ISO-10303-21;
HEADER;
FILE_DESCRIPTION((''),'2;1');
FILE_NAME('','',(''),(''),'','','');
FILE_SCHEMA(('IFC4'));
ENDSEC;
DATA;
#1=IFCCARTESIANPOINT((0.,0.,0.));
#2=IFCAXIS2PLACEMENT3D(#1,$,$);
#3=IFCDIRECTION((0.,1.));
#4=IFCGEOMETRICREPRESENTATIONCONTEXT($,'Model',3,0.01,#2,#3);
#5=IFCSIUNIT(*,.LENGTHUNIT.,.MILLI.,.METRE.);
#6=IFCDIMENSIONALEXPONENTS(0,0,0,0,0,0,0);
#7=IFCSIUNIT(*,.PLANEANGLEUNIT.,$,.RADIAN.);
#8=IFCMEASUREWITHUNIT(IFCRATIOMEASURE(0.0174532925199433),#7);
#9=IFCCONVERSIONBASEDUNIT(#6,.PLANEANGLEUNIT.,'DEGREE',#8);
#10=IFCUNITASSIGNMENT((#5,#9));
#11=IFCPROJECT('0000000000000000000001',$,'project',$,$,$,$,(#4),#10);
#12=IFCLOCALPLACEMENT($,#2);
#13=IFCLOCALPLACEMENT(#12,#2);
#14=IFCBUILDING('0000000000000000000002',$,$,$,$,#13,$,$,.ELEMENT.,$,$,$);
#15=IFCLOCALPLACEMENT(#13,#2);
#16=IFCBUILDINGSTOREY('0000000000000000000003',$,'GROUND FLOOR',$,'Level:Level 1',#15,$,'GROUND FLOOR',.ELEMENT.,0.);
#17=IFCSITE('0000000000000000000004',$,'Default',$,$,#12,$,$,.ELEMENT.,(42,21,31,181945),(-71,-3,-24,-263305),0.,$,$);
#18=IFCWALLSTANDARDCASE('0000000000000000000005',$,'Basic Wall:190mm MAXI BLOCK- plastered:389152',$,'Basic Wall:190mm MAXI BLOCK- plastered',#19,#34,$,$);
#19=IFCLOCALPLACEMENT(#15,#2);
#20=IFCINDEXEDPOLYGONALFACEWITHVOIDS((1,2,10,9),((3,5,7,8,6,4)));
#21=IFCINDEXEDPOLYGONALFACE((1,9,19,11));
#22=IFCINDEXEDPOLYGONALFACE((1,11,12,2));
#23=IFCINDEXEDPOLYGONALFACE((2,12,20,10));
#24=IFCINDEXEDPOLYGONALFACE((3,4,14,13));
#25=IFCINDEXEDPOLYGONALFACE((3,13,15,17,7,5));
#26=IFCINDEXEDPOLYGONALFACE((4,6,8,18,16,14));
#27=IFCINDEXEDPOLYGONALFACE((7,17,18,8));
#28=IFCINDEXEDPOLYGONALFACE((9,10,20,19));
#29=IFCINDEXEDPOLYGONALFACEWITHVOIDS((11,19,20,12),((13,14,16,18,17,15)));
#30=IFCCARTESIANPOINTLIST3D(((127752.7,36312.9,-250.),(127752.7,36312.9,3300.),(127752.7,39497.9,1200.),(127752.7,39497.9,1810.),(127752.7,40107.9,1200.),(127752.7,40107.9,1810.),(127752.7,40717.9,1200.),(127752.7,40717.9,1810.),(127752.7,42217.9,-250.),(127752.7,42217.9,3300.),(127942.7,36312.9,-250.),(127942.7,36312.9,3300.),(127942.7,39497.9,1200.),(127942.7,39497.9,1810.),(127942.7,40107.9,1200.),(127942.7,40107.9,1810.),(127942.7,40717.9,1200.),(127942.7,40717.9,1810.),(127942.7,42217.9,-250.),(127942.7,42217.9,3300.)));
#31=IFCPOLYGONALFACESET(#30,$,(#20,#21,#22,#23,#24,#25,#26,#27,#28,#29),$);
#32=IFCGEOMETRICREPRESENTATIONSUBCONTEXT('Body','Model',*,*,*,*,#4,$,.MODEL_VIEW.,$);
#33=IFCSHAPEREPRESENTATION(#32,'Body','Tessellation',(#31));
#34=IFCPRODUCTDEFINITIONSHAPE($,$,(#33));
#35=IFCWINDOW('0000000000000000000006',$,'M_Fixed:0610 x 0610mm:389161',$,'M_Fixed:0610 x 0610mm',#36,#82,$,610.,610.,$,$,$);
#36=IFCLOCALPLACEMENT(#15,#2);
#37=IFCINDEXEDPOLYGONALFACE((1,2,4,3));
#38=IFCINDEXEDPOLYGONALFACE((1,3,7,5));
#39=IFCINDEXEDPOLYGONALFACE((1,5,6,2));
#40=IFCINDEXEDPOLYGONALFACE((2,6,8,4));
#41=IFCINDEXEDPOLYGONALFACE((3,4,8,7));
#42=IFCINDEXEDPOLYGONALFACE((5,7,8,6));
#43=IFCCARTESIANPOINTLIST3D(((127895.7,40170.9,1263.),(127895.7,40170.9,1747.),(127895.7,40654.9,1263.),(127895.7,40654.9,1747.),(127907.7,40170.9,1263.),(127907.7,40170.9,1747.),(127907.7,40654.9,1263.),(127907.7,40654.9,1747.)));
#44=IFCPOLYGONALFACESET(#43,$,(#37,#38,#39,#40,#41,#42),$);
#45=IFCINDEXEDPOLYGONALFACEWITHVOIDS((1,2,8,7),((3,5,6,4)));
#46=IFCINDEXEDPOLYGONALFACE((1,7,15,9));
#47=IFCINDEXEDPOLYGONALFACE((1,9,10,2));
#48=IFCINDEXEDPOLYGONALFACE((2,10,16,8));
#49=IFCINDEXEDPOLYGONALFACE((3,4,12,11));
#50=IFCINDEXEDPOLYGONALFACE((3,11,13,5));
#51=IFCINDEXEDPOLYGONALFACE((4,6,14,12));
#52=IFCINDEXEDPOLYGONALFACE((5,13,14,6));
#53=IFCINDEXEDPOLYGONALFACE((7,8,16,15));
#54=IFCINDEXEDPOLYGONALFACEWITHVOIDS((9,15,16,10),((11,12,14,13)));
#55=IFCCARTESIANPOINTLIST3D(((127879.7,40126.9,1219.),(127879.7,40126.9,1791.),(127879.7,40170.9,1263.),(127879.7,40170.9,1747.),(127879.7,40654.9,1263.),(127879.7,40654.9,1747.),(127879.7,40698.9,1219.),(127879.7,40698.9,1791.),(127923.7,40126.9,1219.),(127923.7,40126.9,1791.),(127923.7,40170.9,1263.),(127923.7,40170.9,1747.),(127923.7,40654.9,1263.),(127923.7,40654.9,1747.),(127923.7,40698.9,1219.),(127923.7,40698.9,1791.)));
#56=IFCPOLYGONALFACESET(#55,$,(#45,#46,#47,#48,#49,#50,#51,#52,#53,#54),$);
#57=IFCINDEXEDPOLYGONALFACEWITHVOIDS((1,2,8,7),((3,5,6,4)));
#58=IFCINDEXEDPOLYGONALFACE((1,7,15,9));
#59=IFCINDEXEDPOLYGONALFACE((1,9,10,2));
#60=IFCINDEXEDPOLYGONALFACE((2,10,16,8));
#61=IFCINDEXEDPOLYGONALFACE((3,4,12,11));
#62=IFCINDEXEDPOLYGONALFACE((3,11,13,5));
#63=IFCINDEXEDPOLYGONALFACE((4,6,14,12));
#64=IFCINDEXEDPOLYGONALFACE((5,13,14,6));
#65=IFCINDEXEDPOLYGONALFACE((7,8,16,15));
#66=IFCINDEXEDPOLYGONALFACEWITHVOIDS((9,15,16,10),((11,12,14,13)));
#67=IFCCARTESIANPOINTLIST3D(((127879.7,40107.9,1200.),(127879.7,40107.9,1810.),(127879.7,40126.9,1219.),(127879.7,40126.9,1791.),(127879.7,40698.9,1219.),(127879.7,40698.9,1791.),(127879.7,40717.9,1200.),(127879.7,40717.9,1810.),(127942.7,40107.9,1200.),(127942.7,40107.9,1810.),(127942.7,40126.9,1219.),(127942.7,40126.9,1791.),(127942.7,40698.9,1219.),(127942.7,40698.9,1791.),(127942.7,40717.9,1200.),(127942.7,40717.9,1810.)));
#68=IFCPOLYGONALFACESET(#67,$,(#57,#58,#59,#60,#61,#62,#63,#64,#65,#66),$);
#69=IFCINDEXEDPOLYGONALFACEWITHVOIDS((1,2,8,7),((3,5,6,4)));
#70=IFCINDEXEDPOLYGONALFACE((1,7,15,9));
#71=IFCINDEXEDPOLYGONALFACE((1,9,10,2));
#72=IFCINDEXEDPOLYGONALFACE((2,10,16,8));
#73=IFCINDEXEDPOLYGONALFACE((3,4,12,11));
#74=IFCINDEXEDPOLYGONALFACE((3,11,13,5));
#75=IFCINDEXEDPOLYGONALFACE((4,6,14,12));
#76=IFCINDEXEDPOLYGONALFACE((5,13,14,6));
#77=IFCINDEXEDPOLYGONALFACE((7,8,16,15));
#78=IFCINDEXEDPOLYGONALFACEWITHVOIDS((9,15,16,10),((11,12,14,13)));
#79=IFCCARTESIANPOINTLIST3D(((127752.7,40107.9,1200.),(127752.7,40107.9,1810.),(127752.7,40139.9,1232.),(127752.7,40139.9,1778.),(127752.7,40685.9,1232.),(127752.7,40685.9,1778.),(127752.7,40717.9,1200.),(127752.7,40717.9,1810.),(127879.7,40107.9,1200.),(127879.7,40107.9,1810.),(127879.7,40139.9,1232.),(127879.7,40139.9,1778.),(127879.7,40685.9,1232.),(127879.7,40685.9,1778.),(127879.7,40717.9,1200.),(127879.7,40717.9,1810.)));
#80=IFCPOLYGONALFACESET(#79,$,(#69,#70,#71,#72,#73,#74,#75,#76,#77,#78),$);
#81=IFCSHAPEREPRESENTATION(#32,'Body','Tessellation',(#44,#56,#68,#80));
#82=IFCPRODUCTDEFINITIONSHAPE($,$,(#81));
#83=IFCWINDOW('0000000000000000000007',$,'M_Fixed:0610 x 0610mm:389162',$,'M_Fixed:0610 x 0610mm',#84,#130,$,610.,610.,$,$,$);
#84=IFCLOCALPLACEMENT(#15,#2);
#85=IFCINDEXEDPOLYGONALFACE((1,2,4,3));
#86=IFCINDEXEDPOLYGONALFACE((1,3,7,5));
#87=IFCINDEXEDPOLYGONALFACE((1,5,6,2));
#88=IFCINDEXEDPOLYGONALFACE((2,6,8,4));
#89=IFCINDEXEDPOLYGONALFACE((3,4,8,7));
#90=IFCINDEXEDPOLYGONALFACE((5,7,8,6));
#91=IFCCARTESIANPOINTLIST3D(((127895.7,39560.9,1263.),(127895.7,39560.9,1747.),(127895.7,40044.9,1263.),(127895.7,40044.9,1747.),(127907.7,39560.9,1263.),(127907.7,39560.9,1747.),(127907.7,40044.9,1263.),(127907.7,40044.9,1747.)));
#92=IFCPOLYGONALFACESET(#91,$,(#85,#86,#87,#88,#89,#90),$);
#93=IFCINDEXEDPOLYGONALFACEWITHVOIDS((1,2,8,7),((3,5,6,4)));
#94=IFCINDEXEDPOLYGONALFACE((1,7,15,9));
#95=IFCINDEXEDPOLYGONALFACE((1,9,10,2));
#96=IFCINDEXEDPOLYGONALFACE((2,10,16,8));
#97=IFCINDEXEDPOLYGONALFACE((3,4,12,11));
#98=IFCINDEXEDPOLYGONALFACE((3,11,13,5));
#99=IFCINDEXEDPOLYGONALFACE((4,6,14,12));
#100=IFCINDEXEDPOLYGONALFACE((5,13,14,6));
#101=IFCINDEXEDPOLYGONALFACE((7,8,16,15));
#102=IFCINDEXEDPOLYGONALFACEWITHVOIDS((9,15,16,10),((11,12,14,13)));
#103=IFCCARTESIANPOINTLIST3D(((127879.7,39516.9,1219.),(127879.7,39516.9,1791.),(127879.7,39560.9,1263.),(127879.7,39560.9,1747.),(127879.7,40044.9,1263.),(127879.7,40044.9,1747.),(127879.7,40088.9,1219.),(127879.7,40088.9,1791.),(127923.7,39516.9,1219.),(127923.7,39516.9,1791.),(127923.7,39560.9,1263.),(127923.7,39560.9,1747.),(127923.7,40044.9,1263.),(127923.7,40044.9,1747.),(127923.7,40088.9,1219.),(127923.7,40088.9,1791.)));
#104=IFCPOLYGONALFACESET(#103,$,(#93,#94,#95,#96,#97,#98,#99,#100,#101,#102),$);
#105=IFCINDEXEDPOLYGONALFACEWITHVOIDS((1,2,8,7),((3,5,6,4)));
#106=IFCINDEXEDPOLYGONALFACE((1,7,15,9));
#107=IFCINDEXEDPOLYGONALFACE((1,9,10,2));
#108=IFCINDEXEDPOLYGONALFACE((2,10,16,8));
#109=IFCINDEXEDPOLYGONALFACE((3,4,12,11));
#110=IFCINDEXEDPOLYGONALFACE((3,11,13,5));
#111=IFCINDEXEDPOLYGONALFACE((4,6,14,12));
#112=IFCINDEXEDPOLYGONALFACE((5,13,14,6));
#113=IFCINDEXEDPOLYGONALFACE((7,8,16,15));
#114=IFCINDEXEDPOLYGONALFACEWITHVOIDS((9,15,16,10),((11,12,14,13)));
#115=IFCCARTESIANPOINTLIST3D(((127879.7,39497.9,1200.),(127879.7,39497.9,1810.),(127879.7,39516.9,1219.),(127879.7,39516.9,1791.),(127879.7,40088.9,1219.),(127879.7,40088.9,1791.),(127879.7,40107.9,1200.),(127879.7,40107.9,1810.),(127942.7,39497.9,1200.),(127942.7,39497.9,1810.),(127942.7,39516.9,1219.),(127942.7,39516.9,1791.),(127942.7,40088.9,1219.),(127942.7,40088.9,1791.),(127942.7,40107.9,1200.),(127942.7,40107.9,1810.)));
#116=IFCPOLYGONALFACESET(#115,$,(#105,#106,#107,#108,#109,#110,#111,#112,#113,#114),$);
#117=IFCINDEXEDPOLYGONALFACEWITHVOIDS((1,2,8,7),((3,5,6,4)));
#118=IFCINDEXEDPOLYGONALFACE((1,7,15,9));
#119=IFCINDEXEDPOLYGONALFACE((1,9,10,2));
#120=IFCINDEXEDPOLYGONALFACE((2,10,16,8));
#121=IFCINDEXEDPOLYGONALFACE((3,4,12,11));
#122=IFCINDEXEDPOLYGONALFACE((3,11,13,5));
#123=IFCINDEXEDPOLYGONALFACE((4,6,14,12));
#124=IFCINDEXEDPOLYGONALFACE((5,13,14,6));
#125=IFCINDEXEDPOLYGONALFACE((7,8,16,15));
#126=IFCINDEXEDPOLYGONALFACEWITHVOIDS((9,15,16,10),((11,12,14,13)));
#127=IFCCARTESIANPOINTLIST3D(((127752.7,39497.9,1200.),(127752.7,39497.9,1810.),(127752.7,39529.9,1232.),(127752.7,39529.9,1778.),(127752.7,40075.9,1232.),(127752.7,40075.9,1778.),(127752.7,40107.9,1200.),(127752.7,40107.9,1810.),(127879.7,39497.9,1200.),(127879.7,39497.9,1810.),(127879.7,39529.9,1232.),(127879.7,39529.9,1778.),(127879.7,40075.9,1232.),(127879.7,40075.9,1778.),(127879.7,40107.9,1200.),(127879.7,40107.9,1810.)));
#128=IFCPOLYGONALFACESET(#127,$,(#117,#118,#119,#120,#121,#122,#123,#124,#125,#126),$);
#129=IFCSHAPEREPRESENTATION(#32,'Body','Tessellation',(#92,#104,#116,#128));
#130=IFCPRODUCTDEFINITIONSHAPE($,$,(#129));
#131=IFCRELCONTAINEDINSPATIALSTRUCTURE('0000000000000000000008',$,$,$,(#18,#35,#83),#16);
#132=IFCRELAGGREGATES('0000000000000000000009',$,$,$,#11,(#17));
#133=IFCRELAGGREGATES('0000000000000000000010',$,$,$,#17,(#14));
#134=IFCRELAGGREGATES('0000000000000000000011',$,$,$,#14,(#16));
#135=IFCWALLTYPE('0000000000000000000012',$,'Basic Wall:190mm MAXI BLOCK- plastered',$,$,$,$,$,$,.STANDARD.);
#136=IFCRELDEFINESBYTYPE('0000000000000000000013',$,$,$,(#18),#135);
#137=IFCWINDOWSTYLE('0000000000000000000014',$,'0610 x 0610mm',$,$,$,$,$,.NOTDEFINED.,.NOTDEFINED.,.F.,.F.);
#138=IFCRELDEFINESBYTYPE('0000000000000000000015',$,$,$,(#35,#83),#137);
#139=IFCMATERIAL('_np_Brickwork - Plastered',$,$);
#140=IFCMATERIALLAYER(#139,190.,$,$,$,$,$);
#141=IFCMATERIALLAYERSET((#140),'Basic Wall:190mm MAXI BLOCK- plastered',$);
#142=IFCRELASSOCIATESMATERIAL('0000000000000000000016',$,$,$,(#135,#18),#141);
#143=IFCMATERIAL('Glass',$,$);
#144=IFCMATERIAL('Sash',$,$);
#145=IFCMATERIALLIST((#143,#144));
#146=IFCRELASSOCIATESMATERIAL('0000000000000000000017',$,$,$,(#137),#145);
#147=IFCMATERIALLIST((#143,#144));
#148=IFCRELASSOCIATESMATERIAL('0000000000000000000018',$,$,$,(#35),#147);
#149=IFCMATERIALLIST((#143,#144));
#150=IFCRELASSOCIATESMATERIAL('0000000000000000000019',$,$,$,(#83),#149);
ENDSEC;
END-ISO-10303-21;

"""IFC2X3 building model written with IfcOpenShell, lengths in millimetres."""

from ifc_helpers import new_model, entity, si_unit, converted_unit, direction, frame, frame_2d, origin, place, context, subcontext, project, spatial, polyline, rectangle, outline, extrude, source, transform, mapped, material, material_list, layer, layer_set, layer_usage, type_object, type_shapes, element, fill, save


model = new_model("IFC2X3")

# Units and contexts
model_context = context("Model", 3, precision=0.01, world=origin(), true_north=direction((0.0, 1.0)))
body_context = subcontext(model_context, "Body", "Model", "MODEL_VIEW")
ifc_project = project(units=[si_unit("LENGTHUNIT", "METRE", prefix="MILLI"), converted_unit("PLANEANGLEUNIT", "DEGREE", entity("IfcRatioMeasure", 0.0174532925199433), si_unit("PLANEANGLEUNIT", "RADIAN"), dimensions=[0, 0, 0, 0, 0, 0, 0])], contexts=[model_context])

# Site, building, storey
site_placement = place(None, origin())
site = spatial("IfcSite", under=ifc_project, at=site_placement, Name="Default", CompositionType="ELEMENT", RefLatitude=(42, 21, 31, 181945), RefLongitude=(-71, -3, -24, -263305), RefElevation=0.0)
building_placement = place(site_placement, origin())
building = spatial("IfcBuilding", under=site, at=building_placement, CompositionType="ELEMENT")
storey_placement = place(building_placement, origin())
storey = spatial("IfcBuildingStorey", under=building, at=storey_placement, Name="GROUND FLOOR", ObjectType="Level:Level 1", LongName="GROUND FLOOR", CompositionType="ELEMENT", Elevation=0.0)

# Wall, openings, windows
ifc_material_1 = material(Name="_np_Brickwork - Plastered")
ifc_layer = layer(ifc_material_1, 190.0)
ifc_layer_set = layer_set([ifc_layer], Name="Basic Wall:190mm MAXI BLOCK- plastered")
ifc_layer_usage_1 = layer_usage(ifc_layer_set, "AXIS2", "NEGATIVE", 95.0)
wall_type = type_object("IfcWallType", Name="Basic Wall:190mm MAXI BLOCK- plastered", PredefinedType="STANDARD", material=ifc_layer_set)
wall_1_placement = place(storey_placement, frame((127847.7, 36312.9, -250.0), z_axis=(0.0, 0.0, 1.0), x_axis=(0.0, 1.0, 0.0)))
wall_1 = element("IfcWallStandardCase", 1, at=wall_1_placement, inside=storey, type_object=wall_type, material=ifc_layer_usage_1, Name="Basic Wall:190mm MAXI BLOCK- plastered:389152", ObjectType="Basic Wall:190mm MAXI BLOCK- plastered", context=body_context, shape_type="SweptSolid", body=[
    extrude(rectangle(XDim=5905.0, YDim=190.0, at=frame_2d((2952.5, 0.0), x_axis=(-1.0, 0.0))), origin(), (0.0, 0.0, 1.0), 3550.0),
])
opening_1_placement = place(wall_1_placement, frame((4405.0, 95.0, 1450.0)))
opening_1 = element("IfcOpeningElement", 2, at=opening_1_placement, cuts=wall_1, ObjectType="Opening", context=body_context, shape_type="SweptSolid", body=[
    extrude(rectangle(XDim=610.0, YDim=610.0, at=frame_2d((305.0, 305.0), x_axis=(1.0, 0.0))), frame((0.0, 0.0, 0.0), z_axis=(0.0, -1.0, 0.0), x_axis=(0.0, 0.0, 1.0)), (0.0, 0.0, 1.0), 190.0),
])
opening_2_placement = place(wall_1_placement, frame((3795.0, 95.0, 1450.0)))
opening_2 = element("IfcOpeningElement", 3, at=opening_2_placement, cuts=wall_1, ObjectType="Opening", context=body_context, shape_type="SweptSolid", body=[
    extrude(rectangle(XDim=610.0, YDim=610.0, at=frame_2d((305.0, 305.0), x_axis=(1.0, 0.0))), frame((0.0, 0.0, 0.0), z_axis=(0.0, -1.0, 0.0), x_axis=(0.0, 0.0, 1.0)), (0.0, 0.0, 1.0), 190.0),
])
ifc_material_2 = material(Name="Glass")
ifc_material_3 = material(Name="Sash")
ifc_material_list_1 = material_list([ifc_material_2, ifc_material_3])
ifc_material_list_2 = material_list([ifc_material_2, ifc_material_3])
window_style = type_object("IfcWindowStyle", Name="0610 x 0610mm", ConstructionType="NOTDEFINED", OperationType="NOTDEFINED", ParameterTakesPrecedence=False, Sizeable=False, material=ifc_material_list_2)
shared_shape = source(origin(), body_context, "Body", "SweptSolid", [
    extrude(rectangle(XDim=12.0, YDim=484.0, at=frame_2d((0.0, 0.0), x_axis=(1.0, 0.0))), frame((305.0, 149.0, 63.0), z_axis=(0.0, 0.0, 1.0), x_axis=(0.0, -1.0, 0.0)), (0.0, 0.0, 1.0), 484.0),
    extrude(outline(polyline([(-286.0, -286.0), (286.0, -286.0), (286.0, 286.0), (-286.0, 286.0), (-286.0, -286.0)]), holes=[polyline([(-242.0, -242.0), (-242.0, 242.0), (242.0, 242.0), (242.0, -242.0), (-242.0, -242.0)])]), frame((305.0, 127.0, 305.0), z_axis=(0.0, 1.0, 0.0), x_axis=(1.0, 0.0, 0.0)), (0.0, 0.0, 1.0), 44.0),
    extrude(outline(polyline([(-305.0, -305.0), (305.0, -305.0), (305.0, 305.0), (-305.0, 305.0), (-305.0, -305.0)]), holes=[polyline([(-286.0, -286.0), (-286.0, 286.0), (286.0, 286.0), (286.0, -286.0), (-286.0, -286.0)])]), frame((305.0, 127.0, 305.0), z_axis=(0.0, 1.0, 0.0), x_axis=(1.0, 0.0, 0.0)), (0.0, 0.0, 1.0), 63.0),
    extrude(outline(polyline([(-305.0, -305.0), (305.0, -305.0), (305.0, 305.0), (-305.0, 305.0), (-305.0, -305.0)]), holes=[polyline([(-273.0, -273.0), (-273.0, 273.0), (273.0, 273.0), (273.0, -273.0), (-273.0, -273.0)])]), frame((305.0, 0.0, 305.0), z_axis=(0.0, 1.0, 0.0), x_axis=(1.0, 0.0, 0.0)), (0.0, 0.0, 1.0), 127.0),
])
type_shapes(window_style, [shared_shape])
window_1_placement = place(opening_1_placement, frame((0.0, 0.0, 0.0), z_axis=(0.0, 0.0, 1.0), x_axis=(-1.0, 0.0, 0.0)))
window_1 = element("IfcWindow", 4, at=window_1_placement, inside=storey, type_object=window_style, material=ifc_material_list_1, Name="M_Fixed:0610 x 0610mm:389161", ObjectType="M_Fixed:0610 x 0610mm", OverallHeight=610.0, OverallWidth=610.0, context=body_context, shape_type="MappedRepresentation", body=[
    mapped(shared_shape, transform((0.0, 0.0, 0.0), scale=1.0)),
])
fill(opening_1, window_1)
ifc_material_list_3 = material_list([ifc_material_2, ifc_material_3])
window_2_placement = place(opening_2_placement, frame((0.0, 0.0, 0.0), z_axis=(0.0, 0.0, 1.0), x_axis=(-1.0, 0.0, 0.0)))
window_2 = element("IfcWindow", 5, at=window_2_placement, inside=storey, type_object=window_style, material=ifc_material_list_3, Name="M_Fixed:0610 x 0610mm:389162", ObjectType="M_Fixed:0610 x 0610mm", OverallHeight=610.0, OverallWidth=610.0, context=body_context, shape_type="MappedRepresentation", body=[
    mapped(shared_shape, transform((0.0, 0.0, 0.0), scale=1.0)),
])
fill(opening_2, window_2)

save(model, "model.ifc")
